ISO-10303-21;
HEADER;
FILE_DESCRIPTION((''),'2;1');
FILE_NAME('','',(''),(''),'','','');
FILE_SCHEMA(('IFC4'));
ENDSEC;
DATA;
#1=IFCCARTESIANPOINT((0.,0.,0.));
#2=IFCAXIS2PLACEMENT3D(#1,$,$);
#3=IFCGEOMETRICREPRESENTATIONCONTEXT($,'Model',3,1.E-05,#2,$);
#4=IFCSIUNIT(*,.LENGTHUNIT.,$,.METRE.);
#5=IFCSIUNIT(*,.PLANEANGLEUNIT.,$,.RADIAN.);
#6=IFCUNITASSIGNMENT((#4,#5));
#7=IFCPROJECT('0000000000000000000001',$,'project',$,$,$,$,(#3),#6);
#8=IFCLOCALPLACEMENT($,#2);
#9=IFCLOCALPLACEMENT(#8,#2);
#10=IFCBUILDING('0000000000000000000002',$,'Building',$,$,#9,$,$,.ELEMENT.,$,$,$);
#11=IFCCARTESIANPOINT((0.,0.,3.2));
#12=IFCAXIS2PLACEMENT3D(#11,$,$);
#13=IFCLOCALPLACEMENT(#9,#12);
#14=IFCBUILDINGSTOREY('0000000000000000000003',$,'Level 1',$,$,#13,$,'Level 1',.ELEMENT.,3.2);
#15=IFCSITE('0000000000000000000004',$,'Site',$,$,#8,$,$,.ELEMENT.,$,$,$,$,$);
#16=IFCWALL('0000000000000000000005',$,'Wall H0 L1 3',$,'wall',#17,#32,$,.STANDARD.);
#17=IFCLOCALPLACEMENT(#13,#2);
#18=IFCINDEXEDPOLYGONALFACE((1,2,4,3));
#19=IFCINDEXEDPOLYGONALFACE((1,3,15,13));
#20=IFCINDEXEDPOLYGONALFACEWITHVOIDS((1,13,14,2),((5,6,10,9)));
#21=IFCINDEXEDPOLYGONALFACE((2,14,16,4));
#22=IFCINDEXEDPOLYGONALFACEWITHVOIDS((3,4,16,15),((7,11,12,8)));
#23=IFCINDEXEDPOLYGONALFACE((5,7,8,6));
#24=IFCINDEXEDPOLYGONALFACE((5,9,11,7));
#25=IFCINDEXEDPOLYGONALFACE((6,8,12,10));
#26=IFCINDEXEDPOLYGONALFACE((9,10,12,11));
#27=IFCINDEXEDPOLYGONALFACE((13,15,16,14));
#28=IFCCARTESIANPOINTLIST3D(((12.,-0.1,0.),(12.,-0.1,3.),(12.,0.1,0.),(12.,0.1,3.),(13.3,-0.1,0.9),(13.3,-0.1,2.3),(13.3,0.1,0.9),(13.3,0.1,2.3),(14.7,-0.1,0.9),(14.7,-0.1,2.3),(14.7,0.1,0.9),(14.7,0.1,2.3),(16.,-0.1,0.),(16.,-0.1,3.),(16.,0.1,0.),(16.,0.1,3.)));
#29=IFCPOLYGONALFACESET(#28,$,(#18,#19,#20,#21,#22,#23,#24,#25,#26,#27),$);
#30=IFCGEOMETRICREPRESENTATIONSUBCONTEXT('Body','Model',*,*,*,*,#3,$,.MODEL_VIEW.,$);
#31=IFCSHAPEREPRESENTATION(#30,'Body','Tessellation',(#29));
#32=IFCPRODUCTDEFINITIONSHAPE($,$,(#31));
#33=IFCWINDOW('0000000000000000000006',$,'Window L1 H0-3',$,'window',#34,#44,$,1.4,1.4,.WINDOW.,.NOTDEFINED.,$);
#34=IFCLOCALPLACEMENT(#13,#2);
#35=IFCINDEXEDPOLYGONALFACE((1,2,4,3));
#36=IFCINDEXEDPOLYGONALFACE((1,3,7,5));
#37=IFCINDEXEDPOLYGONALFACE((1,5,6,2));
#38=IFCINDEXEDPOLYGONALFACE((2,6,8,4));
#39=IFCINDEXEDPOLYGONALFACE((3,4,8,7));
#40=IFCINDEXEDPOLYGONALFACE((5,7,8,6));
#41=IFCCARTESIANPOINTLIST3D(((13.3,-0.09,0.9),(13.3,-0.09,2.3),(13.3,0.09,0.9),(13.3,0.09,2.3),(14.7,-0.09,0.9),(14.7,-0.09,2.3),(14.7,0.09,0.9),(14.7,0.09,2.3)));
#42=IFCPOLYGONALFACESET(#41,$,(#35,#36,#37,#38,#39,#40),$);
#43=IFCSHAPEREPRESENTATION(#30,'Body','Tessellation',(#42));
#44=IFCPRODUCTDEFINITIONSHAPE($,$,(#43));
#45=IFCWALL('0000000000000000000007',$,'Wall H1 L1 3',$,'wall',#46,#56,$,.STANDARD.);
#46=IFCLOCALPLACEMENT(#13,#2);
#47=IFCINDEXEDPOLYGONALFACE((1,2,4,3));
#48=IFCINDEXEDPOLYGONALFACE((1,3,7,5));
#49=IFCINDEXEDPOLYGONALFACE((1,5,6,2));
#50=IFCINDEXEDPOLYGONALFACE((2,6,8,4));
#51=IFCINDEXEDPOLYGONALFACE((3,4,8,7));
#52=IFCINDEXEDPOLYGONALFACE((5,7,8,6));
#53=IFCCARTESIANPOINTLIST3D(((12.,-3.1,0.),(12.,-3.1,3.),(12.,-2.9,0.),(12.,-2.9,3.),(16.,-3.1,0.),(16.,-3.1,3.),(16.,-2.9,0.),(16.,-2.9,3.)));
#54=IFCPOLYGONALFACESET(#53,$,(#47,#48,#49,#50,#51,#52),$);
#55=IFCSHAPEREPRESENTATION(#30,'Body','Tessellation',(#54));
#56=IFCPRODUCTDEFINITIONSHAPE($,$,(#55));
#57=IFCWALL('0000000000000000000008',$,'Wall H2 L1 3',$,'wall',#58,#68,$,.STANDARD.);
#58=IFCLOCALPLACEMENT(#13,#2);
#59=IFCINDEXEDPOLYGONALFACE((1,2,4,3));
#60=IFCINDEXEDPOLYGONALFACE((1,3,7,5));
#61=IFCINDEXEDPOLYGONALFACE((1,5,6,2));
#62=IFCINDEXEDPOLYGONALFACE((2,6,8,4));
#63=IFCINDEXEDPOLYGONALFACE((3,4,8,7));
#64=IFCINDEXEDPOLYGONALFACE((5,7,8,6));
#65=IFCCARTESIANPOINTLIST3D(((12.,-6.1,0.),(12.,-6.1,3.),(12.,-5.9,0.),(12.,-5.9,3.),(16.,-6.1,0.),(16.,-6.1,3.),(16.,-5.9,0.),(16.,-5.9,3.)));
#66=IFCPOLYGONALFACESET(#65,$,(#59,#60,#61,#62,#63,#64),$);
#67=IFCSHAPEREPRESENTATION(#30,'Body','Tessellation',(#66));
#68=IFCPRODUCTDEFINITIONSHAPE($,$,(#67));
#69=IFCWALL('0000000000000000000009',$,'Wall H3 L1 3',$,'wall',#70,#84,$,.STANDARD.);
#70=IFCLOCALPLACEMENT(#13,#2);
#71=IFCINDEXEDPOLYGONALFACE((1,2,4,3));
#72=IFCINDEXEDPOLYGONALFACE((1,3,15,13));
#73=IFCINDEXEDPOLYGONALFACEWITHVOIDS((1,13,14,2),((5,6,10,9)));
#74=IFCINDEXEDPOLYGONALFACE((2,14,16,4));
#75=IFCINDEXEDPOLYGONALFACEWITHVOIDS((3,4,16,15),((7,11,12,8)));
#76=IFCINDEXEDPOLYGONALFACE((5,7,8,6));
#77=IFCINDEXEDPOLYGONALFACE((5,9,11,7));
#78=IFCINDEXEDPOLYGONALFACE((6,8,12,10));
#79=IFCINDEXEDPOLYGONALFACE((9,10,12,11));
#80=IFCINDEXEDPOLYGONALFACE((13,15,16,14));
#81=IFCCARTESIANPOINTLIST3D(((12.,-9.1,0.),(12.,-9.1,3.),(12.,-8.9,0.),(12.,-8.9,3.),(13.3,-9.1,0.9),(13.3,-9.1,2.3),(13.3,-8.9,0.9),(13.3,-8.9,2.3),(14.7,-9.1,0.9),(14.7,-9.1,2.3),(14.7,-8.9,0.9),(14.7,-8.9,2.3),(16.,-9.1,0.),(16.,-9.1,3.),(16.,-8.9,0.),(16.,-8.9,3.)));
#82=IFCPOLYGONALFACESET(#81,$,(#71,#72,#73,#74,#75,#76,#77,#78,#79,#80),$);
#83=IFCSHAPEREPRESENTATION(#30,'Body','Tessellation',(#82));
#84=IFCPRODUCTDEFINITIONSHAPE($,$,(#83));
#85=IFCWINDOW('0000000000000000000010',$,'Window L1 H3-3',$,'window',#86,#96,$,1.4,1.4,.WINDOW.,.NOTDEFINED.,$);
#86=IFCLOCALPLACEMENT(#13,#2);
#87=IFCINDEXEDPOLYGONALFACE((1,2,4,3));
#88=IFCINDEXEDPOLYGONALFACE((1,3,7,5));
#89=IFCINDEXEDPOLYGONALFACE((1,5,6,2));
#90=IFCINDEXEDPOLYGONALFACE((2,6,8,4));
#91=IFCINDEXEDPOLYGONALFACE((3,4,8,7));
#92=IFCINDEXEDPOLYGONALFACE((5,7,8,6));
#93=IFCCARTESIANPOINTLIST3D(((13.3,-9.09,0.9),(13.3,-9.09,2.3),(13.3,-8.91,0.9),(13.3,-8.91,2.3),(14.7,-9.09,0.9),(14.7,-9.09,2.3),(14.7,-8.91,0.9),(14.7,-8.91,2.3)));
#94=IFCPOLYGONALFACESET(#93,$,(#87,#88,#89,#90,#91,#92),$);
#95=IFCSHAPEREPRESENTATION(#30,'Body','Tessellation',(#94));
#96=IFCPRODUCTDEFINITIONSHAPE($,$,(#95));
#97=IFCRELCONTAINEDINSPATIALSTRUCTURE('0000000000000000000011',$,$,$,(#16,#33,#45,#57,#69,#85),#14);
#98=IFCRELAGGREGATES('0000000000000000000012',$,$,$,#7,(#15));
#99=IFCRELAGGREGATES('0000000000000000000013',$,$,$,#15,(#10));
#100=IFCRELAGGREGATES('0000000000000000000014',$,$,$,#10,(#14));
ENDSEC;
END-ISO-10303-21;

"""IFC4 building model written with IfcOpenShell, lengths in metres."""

from ifc_helpers import new_model, si_unit, frame, frame_2d, origin, origin_2d, place, context, subcontext, project, spatial, rectangle, extrude, element, fill, save


model = new_model("IFC4")

# Units and contexts
model_context = context("Model", 3, precision=1e-05, world=origin())
body_context = subcontext(model_context, "Body", "Model", "MODEL_VIEW")
ifc_project = project(units=[si_unit("LENGTHUNIT", "METRE"), si_unit("PLANEANGLEUNIT", "RADIAN")], contexts=[model_context])

# Site, building, storey
site_placement = place(None, origin())
site = spatial("IfcSite", under=ifc_project, at=site_placement, Name="Site", CompositionType="ELEMENT")
building_placement = place(site_placement, origin())
building = spatial("IfcBuilding", under=site, at=building_placement, Name="Building", CompositionType="ELEMENT")
storey_placement = place(building_placement, frame((0.0, 0.0, 3.2)))
storey = spatial("IfcBuildingStorey", under=building, at=storey_placement, Name="Level 1", LongName="Level 1", CompositionType="ELEMENT", Elevation=3.2)

# Wall, opening, window
wall_1_placement = place(storey_placement, frame((12.0, 0.0, 0.0), z_axis=(0.0, 0.0, 1.0), x_axis=(1.0, 0.0, 0.0)))
wall_1 = element("IfcWall", 1, at=wall_1_placement, inside=storey, Name="Wall H0 L1 3", ObjectType="wall", PredefinedType="STANDARD", context=body_context, shape_type="SweptSolid", body=[
    extrude(rectangle(XDim=4.0, YDim=0.2, at=frame_2d((2.0, 0.0))), origin(), (0.0, 0.0, 1.0), 3.0),
])
opening_1_placement = place(storey_placement, frame((14.0, 0.0, 0.9), z_axis=(0.0, 0.0, 1.0), x_axis=(1.0, 0.0, 0.0)))
opening_1 = element("IfcOpeningElement", 2, at=opening_1_placement, cuts=wall_1, ObjectType="Opening", PredefinedType="OPENING", context=body_context, shape_type="SweptSolid", body=[
    extrude(rectangle(XDim=1.4, YDim=0.22, at=origin_2d()), origin(), (0.0, 0.0, 1.0), 1.4),
])
window_1_placement = place(storey_placement, frame((14.0, 0.0, 0.9), z_axis=(0.0, 0.0, 1.0), x_axis=(1.0, 0.0, 0.0)))
window_1 = element("IfcWindow", 3, at=window_1_placement, inside=storey, Name="Window L1 H0-3", ObjectType="window", OverallHeight=1.4, OverallWidth=1.4, PartitioningType="NOTDEFINED", PredefinedType="WINDOW", context=body_context, shape_type="SweptSolid", body=[
    extrude(rectangle(XDim=1.4, YDim=0.18, at=origin_2d()), origin(), (0.0, 0.0, 1.0), 1.4),
])
fill(opening_1, window_1)

# Walls
for number, where, z_axis, x_axis, name in (
    (4, (12.0, -3.0, 0.0), (0.0, 0.0, 1.0), (1.0, 0.0, 0.0), "Wall H1 L1 3"),
    (5, (12.0, -6.0, 0.0), (0.0, 0.0, 1.0), (1.0, 0.0, 0.0), "Wall H2 L1 3"),
):
    element("IfcWall", number, at=place(storey_placement, frame(where, z_axis=z_axis, x_axis=x_axis)), inside=storey, Name=name, ObjectType="wall", PredefinedType="STANDARD", context=body_context, shape_type="SweptSolid", body=[
        extrude(rectangle(XDim=4.0, YDim=0.2, at=frame_2d((2.0, 0.0))), origin(), (0.0, 0.0, 1.0), 3.0),
    ])

# Wall, opening, window
wall_2_placement = place(storey_placement, frame((12.0, -9.0, 0.0), z_axis=(0.0, 0.0, 1.0), x_axis=(1.0, 0.0, 0.0)))
wall_2 = element("IfcWall", 6, at=wall_2_placement, inside=storey, Name="Wall H3 L1 3", ObjectType="wall", PredefinedType="STANDARD", context=body_context, shape_type="SweptSolid", body=[
    extrude(rectangle(XDim=4.0, YDim=0.2, at=frame_2d((2.0, 0.0))), origin(), (0.0, 0.0, 1.0), 3.0),
])
opening_2_placement = place(storey_placement, frame((14.0, -9.0, 0.9), z_axis=(0.0, 0.0, 1.0), x_axis=(1.0, 0.0, 0.0)))
opening_2 = element("IfcOpeningElement", 7, at=opening_2_placement, cuts=wall_2, ObjectType="Opening", PredefinedType="OPENING", context=body_context, shape_type="SweptSolid", body=[
    extrude(rectangle(XDim=1.4, YDim=0.22, at=origin_2d()), origin(), (0.0, 0.0, 1.0), 1.4),
])
window_2_placement = place(storey_placement, frame((14.0, -9.0, 0.9), z_axis=(0.0, 0.0, 1.0), x_axis=(1.0, 0.0, 0.0)))
window_2 = element("IfcWindow", 8, at=window_2_placement, inside=storey, Name="Window L1 H3-3", ObjectType="window", OverallHeight=1.4, OverallWidth=1.4, PartitioningType="NOTDEFINED", PredefinedType="WINDOW", context=body_context, shape_type="SweptSolid", body=[
    extrude(rectangle(XDim=1.4, YDim=0.18, at=origin_2d()), origin(), (0.0, 0.0, 1.0), 1.4),
])
fill(opening_2, window_2)

save(model, "model.ifc")
